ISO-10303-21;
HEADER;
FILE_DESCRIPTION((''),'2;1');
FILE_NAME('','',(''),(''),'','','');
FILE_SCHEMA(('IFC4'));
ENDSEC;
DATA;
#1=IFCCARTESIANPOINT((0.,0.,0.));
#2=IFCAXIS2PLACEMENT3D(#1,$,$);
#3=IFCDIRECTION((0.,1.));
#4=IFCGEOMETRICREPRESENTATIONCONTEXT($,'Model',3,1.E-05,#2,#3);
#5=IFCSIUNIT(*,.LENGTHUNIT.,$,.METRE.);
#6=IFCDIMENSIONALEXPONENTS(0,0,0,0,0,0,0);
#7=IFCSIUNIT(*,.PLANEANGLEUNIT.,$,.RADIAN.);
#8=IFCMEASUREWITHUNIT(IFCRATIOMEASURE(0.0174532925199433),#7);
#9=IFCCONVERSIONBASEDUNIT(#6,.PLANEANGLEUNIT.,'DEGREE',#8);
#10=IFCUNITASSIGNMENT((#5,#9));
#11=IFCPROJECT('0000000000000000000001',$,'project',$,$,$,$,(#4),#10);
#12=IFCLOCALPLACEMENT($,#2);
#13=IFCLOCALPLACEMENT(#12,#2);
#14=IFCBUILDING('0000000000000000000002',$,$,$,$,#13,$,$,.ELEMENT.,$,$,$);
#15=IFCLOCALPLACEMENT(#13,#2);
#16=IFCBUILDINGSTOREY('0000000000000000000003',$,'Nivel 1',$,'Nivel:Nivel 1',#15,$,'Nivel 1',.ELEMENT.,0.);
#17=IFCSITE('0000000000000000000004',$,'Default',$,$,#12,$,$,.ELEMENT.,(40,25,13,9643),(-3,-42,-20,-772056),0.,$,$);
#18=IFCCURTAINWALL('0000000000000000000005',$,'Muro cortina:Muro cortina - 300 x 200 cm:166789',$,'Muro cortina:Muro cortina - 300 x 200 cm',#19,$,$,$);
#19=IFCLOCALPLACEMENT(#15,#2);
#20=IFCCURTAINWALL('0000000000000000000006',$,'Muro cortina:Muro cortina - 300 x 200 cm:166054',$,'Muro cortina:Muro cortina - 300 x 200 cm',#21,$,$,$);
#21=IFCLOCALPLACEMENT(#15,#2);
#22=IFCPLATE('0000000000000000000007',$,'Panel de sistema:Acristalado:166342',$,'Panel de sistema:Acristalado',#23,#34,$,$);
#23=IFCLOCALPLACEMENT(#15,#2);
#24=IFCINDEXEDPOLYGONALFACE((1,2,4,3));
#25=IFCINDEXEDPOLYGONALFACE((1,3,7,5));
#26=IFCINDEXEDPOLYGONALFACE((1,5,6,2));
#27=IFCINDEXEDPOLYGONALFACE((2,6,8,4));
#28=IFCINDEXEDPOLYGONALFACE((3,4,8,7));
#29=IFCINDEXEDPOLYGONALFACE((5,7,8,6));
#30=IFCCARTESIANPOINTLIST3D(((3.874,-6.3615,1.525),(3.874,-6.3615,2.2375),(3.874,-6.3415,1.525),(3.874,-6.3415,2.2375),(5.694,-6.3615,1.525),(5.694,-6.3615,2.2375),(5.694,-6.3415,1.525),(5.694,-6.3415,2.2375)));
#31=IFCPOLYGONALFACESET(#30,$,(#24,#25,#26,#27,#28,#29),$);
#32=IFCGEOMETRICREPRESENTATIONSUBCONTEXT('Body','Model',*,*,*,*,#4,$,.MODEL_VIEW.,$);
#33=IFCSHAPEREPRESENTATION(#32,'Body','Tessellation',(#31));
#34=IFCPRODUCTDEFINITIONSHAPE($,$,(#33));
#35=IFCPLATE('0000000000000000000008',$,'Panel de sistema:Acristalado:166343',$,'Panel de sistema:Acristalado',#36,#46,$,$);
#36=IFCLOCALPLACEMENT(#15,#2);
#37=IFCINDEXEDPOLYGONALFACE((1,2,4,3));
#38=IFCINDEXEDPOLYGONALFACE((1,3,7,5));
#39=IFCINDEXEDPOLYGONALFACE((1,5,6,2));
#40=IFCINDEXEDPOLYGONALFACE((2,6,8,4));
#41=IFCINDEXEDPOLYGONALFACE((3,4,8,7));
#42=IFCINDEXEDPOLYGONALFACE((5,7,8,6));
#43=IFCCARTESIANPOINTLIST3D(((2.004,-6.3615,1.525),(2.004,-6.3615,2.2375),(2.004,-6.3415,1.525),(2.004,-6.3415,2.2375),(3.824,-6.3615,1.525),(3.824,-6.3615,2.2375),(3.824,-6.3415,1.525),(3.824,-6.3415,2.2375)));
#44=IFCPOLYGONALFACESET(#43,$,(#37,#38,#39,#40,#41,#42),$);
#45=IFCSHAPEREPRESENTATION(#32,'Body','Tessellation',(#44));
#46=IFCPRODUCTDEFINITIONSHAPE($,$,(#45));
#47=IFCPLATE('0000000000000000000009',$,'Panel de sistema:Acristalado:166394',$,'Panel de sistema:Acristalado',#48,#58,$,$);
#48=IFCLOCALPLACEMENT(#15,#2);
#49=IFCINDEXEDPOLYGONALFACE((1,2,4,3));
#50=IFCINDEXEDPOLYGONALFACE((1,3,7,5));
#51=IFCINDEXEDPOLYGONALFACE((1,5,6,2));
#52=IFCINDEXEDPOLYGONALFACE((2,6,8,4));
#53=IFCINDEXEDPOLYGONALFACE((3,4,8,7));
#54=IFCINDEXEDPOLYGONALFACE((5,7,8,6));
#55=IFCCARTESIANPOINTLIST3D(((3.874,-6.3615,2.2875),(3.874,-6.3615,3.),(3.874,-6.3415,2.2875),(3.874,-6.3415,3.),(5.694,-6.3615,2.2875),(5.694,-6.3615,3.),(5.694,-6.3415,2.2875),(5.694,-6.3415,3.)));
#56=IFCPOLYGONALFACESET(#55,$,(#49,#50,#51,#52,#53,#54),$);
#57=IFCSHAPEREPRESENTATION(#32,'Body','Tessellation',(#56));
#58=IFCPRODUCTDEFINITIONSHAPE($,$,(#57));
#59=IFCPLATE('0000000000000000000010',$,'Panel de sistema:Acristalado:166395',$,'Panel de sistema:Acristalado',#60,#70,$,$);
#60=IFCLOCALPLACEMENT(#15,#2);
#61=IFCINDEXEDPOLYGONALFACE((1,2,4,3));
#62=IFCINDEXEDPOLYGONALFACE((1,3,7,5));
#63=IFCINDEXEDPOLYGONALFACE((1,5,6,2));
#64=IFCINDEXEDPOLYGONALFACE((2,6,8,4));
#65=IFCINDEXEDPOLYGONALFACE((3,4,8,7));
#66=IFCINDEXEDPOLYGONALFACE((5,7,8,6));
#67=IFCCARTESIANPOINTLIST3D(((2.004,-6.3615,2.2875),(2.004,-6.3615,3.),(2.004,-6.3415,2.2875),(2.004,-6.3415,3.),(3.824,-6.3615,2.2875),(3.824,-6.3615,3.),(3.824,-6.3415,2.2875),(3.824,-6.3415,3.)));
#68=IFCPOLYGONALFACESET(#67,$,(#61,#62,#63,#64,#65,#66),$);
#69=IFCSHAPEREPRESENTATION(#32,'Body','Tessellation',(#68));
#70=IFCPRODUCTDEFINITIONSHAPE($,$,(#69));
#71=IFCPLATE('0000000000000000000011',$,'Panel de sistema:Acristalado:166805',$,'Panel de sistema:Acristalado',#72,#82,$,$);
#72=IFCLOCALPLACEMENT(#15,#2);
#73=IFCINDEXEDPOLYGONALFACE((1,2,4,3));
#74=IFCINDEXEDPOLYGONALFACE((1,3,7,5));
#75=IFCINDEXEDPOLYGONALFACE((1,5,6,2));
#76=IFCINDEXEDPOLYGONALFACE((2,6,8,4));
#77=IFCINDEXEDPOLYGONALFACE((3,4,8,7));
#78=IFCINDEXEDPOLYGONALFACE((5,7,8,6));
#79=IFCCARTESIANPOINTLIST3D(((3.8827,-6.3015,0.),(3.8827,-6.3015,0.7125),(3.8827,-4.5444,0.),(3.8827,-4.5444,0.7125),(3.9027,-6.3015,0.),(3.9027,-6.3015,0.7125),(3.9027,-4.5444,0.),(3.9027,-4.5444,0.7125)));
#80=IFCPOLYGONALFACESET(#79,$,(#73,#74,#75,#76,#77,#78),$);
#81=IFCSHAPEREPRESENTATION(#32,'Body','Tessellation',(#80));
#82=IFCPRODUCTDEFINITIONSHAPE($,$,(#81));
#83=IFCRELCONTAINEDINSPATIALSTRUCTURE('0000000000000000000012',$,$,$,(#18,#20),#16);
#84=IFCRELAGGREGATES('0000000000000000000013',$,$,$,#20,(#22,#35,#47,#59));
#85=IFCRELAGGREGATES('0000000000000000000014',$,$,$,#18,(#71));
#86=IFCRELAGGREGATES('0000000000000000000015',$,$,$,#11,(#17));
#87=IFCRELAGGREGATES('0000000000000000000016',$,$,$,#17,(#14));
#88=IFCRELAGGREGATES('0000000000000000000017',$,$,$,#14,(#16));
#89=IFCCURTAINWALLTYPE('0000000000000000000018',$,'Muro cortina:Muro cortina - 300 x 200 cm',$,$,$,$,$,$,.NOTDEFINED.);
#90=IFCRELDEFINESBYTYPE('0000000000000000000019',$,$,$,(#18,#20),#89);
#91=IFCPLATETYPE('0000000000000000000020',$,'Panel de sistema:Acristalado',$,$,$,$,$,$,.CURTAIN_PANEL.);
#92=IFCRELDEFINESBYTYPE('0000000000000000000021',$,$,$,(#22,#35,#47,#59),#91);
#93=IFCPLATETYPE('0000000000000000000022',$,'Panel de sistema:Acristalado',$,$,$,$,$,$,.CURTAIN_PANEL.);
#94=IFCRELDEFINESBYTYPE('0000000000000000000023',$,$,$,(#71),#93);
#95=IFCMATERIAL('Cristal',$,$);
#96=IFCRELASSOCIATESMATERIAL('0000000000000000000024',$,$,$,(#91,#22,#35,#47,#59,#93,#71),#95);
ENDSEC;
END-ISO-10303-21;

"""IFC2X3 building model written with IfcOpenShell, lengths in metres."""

from ifc_helpers import new_model, entity, si_unit, converted_unit, direction, frame, origin, origin_2d_with_axis, place, context, subcontext, project, spatial, rectangle, extrude, source, transform, mapped, material, type_object, type_shapes, element, aggregate, save


model = new_model("IFC2X3")

# Units and contexts
model_context = context("Model", 3, precision=1e-05, world=origin(), true_north=direction((0.0, 1.0)))
body_context = subcontext(model_context, "Body", "Model", "MODEL_VIEW")
ifc_project = project(units=[si_unit("LENGTHUNIT", "METRE"), converted_unit("PLANEANGLEUNIT", "DEGREE", entity("IfcRatioMeasure", 0.0174532925199433), si_unit("PLANEANGLEUNIT", "RADIAN"), dimensions=[0, 0, 0, 0, 0, 0, 0])], contexts=[model_context])

# Site, building, storey
site_placement = place(None, origin())
site = spatial("IfcSite", under=ifc_project, at=site_placement, Name="Default", CompositionType="ELEMENT", RefLatitude=(40, 25, 13, 9643), RefLongitude=(-3, -42, -20, -772056), RefElevation=0.0)
building_placement = place(site_placement, origin())
building = spatial("IfcBuilding", under=site, at=building_placement, CompositionType="ELEMENT")
storey_placement = place(building_placement, origin())
storey = spatial("IfcBuildingStorey", under=building, at=storey_placement, Name="Nivel 1", ObjectType="Nivel:Nivel 1", LongName="Nivel 1", CompositionType="ELEMENT", Elevation=0.0)

# Curtain walls
curtain_wall_type = type_object("IfcCurtainWallType", Name="Muro cortina:Muro cortina - 300 x 200 cm", PredefinedType="NOTDEFINED")
curtain_wall_1_placement = place(storey_placement, origin())
curtain_wall_1 = element("IfcCurtainWall", 1, at=curtain_wall_1_placement, inside=storey, type_object=curtain_wall_type, Name="Muro cortina:Muro cortina - 300 x 200 cm:166789", ObjectType="Muro cortina:Muro cortina - 300 x 200 cm")
curtain_wall_2_placement = place(storey_placement, origin())
curtain_wall_2 = element("IfcCurtainWall", 2, at=curtain_wall_2_placement, inside=storey, type_object=curtain_wall_type, Name="Muro cortina:Muro cortina - 300 x 200 cm:166054", ObjectType="Muro cortina:Muro cortina - 300 x 200 cm")

# Plates
ifc_material_1 = material(Name="Cristal")
plate_type_1 = type_object("IfcPlateType", Name="Panel de sistema:Acristalado", PredefinedType="CURTAIN_PANEL", material=ifc_material_1)
shared_shape_1 = source(origin(), body_context, "Body", "SweptSolid", [
    extrude(rectangle(XDim=0.02, YDim=1.82, at=origin_2d_with_axis()), frame((0.0, 0.0, 0.0), z_axis=(0.0, 0.0, 1.0), x_axis=(0.0, 1.0, 0.0)), (0.0, 0.0, 1.0), 0.7125),
])
type_shapes(plate_type_1, [shared_shape_1])
plate_1_placement = place(curtain_wall_2_placement, frame((4.784, -6.3515, 1.525), z_axis=(0.0, 0.0, 1.0), x_axis=(-1.0, 0.0, 0.0)))
plate_1 = element("IfcPlate", 3, at=plate_1_placement, type_object=plate_type_1, material=ifc_material_1, Name="Panel de sistema:Acristalado:166342", ObjectType="Panel de sistema:Acristalado", context=body_context, shape_type="MappedRepresentation", body=[
    mapped(shared_shape_1, transform((0.0, 0.0, 0.0), scale=1.0)),
])
plate_2_placement = place(curtain_wall_2_placement, frame((2.914, -6.3515, 1.525), z_axis=(0.0, 0.0, 1.0), x_axis=(-1.0, 0.0, 0.0)))
plate_2 = element("IfcPlate", 4, at=plate_2_placement, type_object=plate_type_1, material=ifc_material_1, Name="Panel de sistema:Acristalado:166343", ObjectType="Panel de sistema:Acristalado", context=body_context, shape_type="MappedRepresentation", body=[
    mapped(shared_shape_1, transform((0.0, 0.0, 0.0), scale=1.0)),
])
plate_3_placement = place(curtain_wall_2_placement, frame((4.784, -6.3515, 2.2875), z_axis=(0.0, 0.0, 1.0), x_axis=(-1.0, 0.0, 0.0)))
plate_3 = element("IfcPlate", 5, at=plate_3_placement, type_object=plate_type_1, material=ifc_material_1, Name="Panel de sistema:Acristalado:166394", ObjectType="Panel de sistema:Acristalado", context=body_context, shape_type="MappedRepresentation", body=[
    mapped(shared_shape_1, transform((0.0, 0.0, 0.0), scale=1.0)),
])
plate_4_placement = place(curtain_wall_2_placement, frame((2.914, -6.3515, 2.2875), z_axis=(0.0, 0.0, 1.0), x_axis=(-1.0, 0.0, 0.0)))
plate_4 = element("IfcPlate", 6, at=plate_4_placement, type_object=plate_type_1, material=ifc_material_1, Name="Panel de sistema:Acristalado:166395", ObjectType="Panel de sistema:Acristalado", context=body_context, shape_type="MappedRepresentation", body=[
    mapped(shared_shape_1, transform((0.0, 0.0, 0.0), scale=1.0)),
])
aggregate(curtain_wall_2, [plate_1, plate_2, plate_3, plate_4])
plate_type_2 = type_object("IfcPlateType", Name="Panel de sistema:Acristalado", PredefinedType="CURTAIN_PANEL", material=ifc_material_1)
shared_shape_2 = source(origin(), body_context, "Body", "SweptSolid", [
    extrude(rectangle(XDim=0.02, YDim=1.7571, at=origin_2d_with_axis()), frame((0.0, 0.0, 0.0), z_axis=(0.0, 0.0, 1.0), x_axis=(0.0, 1.0, 0.0)), (0.0, 0.0, 1.0), 0.7125),
])
type_shapes(plate_type_2, [shared_shape_2])
plate_5_placement = place(curtain_wall_1_placement, frame((3.8927, -5.423, 0.0), z_axis=(0.0, 0.0, 1.0), x_axis=(0.0, -1.0, 0.0)))
plate_5 = element("IfcPlate", 7, at=plate_5_placement, type_object=plate_type_2, material=ifc_material_1, Name="Panel de sistema:Acristalado:166805", ObjectType="Panel de sistema:Acristalado", context=body_context, shape_type="MappedRepresentation", body=[
    mapped(shared_shape_2, transform((0.0, 0.0, 0.0), scale=1.0)),
])
aggregate(curtain_wall_1, [plate_5])

save(model, "model.ifc")
